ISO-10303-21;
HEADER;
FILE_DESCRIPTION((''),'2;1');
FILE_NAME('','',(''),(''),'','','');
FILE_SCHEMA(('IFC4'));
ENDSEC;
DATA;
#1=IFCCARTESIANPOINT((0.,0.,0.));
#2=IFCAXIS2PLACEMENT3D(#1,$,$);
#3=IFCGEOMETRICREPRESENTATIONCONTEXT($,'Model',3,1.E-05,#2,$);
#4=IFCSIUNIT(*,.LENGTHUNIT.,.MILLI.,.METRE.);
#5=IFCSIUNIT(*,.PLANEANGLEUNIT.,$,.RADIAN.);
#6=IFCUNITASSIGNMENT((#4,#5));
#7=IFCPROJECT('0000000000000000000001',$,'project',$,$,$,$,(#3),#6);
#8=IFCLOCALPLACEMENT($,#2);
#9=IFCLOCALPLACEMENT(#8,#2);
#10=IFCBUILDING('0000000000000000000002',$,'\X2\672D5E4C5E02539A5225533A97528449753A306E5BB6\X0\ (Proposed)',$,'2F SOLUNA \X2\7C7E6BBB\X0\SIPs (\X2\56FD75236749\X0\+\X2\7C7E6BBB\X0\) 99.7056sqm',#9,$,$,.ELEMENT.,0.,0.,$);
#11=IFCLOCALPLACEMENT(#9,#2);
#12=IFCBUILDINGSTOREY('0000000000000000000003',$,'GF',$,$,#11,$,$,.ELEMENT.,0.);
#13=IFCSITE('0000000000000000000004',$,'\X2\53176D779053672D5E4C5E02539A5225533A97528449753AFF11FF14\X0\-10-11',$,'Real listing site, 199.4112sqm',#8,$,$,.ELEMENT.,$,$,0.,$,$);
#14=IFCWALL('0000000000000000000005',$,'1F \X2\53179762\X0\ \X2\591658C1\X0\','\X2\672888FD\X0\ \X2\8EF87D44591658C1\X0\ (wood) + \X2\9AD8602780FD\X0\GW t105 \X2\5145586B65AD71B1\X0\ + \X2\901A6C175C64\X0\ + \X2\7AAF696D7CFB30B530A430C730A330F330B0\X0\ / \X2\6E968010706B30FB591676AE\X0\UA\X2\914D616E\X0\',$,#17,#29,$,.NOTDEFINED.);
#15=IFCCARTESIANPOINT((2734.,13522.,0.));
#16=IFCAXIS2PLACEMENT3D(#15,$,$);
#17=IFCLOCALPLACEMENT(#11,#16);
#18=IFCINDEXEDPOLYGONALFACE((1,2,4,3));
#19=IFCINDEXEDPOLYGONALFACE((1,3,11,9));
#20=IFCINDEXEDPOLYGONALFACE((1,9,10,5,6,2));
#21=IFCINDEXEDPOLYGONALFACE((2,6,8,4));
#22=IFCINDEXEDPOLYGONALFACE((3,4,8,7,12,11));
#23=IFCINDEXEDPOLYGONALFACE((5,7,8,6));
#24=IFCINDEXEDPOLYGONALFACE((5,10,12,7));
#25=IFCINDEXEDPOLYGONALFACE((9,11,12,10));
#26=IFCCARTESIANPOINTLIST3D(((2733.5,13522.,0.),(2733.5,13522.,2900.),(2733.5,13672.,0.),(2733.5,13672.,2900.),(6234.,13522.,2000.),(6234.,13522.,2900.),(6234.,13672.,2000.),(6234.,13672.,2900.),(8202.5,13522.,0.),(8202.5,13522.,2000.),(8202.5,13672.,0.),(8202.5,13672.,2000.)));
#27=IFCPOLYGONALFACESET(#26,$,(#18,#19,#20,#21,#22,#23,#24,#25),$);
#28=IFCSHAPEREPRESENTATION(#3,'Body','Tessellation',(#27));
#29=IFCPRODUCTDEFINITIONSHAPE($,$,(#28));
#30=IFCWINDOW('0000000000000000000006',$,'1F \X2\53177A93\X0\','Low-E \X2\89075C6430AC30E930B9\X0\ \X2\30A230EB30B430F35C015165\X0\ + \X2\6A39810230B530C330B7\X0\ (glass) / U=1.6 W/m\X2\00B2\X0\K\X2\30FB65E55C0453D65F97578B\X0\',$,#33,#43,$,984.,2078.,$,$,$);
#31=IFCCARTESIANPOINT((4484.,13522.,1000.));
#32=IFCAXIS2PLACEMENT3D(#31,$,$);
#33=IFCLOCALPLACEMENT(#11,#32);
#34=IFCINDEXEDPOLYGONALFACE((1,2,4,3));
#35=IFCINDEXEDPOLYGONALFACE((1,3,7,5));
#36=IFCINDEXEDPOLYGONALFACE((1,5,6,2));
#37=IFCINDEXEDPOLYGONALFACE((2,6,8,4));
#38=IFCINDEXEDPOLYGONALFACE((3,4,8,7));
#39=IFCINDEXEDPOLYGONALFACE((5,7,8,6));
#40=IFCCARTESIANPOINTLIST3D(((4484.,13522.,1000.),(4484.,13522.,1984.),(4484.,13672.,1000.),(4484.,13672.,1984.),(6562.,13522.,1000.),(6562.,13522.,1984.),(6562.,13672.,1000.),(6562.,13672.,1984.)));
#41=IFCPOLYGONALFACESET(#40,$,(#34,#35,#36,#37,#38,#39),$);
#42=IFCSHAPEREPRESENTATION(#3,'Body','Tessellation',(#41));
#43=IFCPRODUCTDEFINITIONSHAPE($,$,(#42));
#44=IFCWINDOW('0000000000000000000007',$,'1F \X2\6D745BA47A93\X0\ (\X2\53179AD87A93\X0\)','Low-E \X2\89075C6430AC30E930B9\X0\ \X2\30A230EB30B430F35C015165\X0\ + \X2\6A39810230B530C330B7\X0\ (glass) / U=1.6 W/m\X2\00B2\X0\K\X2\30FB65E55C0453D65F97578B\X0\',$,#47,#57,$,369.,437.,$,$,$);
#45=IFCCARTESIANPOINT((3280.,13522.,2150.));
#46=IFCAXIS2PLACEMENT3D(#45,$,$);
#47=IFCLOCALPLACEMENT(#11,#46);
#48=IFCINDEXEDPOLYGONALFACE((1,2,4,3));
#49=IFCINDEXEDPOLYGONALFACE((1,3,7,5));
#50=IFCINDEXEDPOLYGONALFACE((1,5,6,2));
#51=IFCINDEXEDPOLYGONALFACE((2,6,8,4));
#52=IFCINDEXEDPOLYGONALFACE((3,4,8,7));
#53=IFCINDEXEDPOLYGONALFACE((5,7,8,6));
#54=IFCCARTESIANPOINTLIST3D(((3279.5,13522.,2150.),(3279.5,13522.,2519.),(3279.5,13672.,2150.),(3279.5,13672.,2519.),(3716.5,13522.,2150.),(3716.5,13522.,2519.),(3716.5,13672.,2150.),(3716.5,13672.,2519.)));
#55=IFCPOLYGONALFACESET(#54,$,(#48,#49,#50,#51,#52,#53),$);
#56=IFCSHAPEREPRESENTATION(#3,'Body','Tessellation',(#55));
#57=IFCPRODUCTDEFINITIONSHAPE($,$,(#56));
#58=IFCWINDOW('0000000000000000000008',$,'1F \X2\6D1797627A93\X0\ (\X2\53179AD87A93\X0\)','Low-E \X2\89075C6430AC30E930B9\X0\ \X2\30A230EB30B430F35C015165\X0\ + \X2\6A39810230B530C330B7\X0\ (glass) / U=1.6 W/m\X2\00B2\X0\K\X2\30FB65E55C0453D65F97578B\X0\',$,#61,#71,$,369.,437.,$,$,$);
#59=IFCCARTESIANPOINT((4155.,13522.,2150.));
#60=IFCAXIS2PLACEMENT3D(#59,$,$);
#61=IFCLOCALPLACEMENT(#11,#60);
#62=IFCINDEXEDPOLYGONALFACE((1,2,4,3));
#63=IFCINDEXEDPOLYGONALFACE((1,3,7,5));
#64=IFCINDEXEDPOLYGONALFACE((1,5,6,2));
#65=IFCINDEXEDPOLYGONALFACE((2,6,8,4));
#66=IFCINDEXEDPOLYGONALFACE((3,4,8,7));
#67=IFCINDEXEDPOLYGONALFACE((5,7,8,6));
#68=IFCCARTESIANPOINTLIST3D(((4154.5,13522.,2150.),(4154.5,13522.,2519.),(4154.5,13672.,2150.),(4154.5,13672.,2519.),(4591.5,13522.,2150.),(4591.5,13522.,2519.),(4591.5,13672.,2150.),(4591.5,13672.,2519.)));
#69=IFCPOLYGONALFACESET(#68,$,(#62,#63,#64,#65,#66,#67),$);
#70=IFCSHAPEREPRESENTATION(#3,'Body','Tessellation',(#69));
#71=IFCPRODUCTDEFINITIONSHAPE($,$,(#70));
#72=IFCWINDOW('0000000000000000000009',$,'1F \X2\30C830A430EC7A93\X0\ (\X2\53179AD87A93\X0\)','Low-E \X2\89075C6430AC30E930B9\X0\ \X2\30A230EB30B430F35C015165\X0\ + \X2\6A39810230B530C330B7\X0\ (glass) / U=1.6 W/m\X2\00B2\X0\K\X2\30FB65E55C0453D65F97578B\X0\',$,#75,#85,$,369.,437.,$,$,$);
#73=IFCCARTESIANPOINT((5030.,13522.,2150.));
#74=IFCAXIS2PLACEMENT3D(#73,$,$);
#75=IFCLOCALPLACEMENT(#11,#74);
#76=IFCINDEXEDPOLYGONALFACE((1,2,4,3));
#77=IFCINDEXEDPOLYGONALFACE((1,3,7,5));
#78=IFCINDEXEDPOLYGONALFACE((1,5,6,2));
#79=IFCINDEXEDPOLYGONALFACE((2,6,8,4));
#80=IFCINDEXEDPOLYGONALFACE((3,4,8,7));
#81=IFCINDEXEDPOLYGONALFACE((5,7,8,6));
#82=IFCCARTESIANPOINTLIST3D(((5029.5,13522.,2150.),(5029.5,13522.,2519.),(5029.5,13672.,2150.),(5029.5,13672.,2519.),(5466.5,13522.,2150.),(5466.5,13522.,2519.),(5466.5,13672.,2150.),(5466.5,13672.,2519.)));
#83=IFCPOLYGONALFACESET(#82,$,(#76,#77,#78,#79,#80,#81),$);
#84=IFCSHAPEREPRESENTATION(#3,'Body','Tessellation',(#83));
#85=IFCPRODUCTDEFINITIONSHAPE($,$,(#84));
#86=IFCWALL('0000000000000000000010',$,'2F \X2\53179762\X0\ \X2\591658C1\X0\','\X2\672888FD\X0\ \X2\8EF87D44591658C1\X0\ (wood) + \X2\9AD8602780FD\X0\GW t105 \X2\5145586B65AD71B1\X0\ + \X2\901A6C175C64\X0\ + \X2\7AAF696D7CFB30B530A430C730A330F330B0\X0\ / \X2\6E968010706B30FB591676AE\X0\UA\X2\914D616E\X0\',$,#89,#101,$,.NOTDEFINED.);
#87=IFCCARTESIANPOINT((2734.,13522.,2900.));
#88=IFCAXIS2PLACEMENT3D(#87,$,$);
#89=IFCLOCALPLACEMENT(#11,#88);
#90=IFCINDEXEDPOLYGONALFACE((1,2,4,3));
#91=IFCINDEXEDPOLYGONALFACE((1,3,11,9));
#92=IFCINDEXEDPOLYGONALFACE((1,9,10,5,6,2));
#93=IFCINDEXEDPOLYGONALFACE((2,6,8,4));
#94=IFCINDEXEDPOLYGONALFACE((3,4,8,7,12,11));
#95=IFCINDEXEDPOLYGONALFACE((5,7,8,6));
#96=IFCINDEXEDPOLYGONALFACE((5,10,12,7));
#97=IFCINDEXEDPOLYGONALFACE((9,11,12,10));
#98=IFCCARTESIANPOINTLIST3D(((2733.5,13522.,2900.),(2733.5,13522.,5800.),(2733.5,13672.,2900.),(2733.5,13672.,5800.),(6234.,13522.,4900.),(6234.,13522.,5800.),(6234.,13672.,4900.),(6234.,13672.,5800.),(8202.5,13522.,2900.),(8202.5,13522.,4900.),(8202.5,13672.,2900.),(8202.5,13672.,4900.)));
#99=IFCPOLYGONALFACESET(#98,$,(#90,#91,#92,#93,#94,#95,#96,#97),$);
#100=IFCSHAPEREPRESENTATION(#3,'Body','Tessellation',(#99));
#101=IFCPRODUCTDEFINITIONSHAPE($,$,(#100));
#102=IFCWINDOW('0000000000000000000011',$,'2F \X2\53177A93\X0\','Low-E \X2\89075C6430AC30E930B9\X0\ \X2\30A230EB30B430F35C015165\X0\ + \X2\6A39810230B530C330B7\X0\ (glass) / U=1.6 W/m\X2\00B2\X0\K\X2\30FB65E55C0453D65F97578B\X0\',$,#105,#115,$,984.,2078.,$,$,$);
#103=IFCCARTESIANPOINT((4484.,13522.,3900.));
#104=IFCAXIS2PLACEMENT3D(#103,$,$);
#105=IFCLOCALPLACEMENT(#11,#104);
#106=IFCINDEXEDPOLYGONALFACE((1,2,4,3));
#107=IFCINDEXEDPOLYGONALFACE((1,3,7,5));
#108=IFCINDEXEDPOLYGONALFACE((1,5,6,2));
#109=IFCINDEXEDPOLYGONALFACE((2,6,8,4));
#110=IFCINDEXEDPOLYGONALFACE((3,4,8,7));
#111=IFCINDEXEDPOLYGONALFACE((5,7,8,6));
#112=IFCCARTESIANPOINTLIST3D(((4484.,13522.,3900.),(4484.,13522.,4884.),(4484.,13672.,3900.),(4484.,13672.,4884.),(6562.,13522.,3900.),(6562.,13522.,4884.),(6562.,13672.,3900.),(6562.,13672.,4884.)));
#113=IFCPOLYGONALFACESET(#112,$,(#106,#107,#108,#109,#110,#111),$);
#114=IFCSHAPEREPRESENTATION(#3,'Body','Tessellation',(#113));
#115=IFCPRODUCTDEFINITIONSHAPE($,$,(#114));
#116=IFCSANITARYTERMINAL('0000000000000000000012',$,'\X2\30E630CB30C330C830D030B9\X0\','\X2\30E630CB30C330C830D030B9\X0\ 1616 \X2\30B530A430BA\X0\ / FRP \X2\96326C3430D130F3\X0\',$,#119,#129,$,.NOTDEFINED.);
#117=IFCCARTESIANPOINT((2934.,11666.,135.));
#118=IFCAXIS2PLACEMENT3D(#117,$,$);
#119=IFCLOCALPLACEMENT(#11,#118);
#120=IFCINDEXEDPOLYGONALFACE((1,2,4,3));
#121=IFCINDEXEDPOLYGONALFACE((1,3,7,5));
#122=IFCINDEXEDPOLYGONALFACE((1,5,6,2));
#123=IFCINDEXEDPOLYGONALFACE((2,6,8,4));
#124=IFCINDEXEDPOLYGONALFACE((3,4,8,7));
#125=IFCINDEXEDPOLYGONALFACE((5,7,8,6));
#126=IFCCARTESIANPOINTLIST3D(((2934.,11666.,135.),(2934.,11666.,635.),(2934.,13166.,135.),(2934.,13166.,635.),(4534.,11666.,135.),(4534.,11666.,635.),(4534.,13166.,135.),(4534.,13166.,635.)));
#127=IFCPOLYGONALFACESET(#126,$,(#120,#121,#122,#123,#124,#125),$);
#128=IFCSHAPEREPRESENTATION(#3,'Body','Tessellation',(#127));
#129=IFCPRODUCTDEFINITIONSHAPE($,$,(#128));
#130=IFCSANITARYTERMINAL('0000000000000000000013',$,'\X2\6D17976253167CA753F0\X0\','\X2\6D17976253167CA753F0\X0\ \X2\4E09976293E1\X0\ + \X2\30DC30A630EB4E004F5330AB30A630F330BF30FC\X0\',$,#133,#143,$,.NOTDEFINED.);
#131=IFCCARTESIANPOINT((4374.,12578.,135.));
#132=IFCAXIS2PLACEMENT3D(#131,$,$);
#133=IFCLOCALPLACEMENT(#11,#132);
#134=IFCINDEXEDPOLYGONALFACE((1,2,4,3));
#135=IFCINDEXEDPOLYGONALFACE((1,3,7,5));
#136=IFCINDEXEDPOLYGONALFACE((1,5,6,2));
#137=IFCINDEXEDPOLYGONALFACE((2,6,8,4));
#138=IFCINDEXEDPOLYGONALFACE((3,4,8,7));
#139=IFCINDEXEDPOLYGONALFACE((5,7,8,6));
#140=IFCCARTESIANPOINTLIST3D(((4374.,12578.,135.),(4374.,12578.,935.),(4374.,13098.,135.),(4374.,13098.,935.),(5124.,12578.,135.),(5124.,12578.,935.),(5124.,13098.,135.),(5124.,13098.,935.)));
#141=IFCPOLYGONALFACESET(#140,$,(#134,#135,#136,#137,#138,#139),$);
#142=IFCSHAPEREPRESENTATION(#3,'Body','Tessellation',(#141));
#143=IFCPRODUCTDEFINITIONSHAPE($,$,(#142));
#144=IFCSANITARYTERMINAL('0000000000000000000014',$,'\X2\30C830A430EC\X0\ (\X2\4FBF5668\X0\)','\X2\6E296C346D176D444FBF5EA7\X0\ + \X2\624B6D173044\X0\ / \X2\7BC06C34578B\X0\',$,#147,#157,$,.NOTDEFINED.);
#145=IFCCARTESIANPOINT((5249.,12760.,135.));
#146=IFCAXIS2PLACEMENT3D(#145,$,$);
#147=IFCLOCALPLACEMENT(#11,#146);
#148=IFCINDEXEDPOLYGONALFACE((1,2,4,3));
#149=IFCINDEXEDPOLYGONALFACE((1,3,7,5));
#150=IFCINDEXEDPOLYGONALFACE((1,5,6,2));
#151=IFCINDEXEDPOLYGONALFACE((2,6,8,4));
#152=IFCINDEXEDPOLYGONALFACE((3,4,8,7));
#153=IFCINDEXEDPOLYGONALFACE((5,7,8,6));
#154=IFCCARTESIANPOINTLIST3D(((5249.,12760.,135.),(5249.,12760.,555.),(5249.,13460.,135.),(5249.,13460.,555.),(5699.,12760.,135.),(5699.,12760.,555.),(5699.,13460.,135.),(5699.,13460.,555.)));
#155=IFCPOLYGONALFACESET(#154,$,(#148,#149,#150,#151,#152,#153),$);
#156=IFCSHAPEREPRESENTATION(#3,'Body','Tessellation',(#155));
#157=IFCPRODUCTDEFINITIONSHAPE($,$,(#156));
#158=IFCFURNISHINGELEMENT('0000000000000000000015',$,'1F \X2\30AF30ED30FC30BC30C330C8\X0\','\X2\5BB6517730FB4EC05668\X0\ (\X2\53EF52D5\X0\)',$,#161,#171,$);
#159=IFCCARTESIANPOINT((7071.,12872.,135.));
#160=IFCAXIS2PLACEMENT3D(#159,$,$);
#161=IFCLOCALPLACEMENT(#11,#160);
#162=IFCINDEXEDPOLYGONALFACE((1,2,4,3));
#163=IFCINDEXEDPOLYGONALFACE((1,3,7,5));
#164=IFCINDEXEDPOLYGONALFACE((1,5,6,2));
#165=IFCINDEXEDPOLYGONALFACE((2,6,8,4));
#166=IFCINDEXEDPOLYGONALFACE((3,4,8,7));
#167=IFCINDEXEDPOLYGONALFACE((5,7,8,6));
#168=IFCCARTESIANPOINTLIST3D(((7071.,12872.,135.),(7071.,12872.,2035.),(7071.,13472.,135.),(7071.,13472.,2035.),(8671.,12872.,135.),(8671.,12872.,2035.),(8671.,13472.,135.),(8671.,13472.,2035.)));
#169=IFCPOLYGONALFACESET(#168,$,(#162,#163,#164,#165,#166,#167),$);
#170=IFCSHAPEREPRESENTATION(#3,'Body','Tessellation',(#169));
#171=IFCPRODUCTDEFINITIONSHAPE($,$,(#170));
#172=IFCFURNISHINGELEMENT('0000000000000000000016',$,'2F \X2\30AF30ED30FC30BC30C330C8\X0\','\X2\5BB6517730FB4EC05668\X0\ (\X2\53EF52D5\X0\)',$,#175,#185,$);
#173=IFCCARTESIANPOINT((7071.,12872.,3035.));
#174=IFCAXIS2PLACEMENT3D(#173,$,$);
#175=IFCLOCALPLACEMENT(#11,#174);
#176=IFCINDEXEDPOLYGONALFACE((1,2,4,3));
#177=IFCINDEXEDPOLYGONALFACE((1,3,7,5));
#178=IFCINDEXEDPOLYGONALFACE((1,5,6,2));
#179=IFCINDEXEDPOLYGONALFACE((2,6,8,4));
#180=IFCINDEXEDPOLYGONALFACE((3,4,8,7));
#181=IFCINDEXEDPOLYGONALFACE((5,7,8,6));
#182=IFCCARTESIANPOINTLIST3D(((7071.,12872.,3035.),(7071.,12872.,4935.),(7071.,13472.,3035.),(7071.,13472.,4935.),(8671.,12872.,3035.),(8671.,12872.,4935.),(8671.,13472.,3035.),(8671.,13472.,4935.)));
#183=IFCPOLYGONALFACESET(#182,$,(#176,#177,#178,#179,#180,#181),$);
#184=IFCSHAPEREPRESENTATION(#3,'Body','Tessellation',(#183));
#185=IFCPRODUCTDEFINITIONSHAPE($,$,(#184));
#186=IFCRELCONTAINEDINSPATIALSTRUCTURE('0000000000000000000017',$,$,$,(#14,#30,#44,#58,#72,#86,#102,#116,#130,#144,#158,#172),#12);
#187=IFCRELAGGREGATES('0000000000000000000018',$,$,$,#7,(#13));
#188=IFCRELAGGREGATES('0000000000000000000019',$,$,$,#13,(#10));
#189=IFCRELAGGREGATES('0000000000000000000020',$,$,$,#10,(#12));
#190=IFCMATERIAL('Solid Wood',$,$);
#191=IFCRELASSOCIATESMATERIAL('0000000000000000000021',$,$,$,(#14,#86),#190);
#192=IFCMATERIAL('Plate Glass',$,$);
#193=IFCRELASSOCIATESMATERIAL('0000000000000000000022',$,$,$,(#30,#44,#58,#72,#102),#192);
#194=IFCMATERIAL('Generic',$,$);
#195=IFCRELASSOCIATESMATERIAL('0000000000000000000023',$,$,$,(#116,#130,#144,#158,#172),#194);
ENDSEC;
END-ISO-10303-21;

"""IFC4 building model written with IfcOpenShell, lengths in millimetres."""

from ifc_helpers import new_model, si_unit, frame, frame_2d, origin, place, context, project, spatial, rectangle, extrude, material, element, fill, save


model = new_model("IFC4")

# Units and contexts
model_context = context("Model", 3, precision=1e-05, world=origin())
ifc_project = project(units=[si_unit("LENGTHUNIT", "METRE", prefix="MILLI"), si_unit("PLANEANGLEUNIT", "RADIAN")], contexts=[model_context])

# Site, building, storey
site_placement = place(None, origin())
site = spatial("IfcSite", under=ifc_project, at=site_placement, Name="北海道札幌市厚別区青葉町１４-10-11", ObjectType="Real listing site, 199.4112sqm", CompositionType="ELEMENT", RefElevation=0.0)
building_placement = place(site_placement, origin())
building = spatial("IfcBuilding", under=site, at=building_placement, Name="札幌市厚別区青葉町の家 (Proposed)", ObjectType="2F SOLUNA 籾殻SIPs (国産杉+籾殻) 99.7056sqm", CompositionType="ELEMENT", ElevationOfRefHeight=0.0, ElevationOfTerrain=0.0)
storey_placement = place(building_placement, origin())
storey = spatial("IfcBuildingStorey", under=building, at=storey_placement, Name="GF", CompositionType="ELEMENT", Elevation=0.0)

# Wall, openings, windows
ifc_material_1 = material(Name="Solid Wood")
wall_1_placement = place(storey_placement, frame((2734.0, 13522.0, 0.0)))
wall_1 = element("IfcWall", 1, at=wall_1_placement, inside=storey, material=ifc_material_1, Name="1F 北面 外壁", Description="木製 軸組外壁 (wood) + 高性能GW t105 充填断熱 + 通気層 + 窯業系サイディング / 準耐火・外皮UA配慮", PredefinedType="NOTDEFINED", context=model_context, shape_type="SweptSolid", body=[
    extrude(rectangle(XDim=5469.0, YDim=150.0, at=frame_2d((2734.0, 75.0))), frame((2734.0, 13522.0, 0.0)), (0.0, 0.0, 1.0), 2900.0),
])
opening_1_placement = place(storey_placement, frame((4484.0, 13522.0, 1000.0)))
opening_1 = element("IfcOpeningElement", 2, at=opening_1_placement, cuts=wall_1, PredefinedType="NOTDEFINED", context=model_context, shape_type="SweptSolid", body=[
    extrude(rectangle(XDim=2078.0, YDim=150.0, at=frame_2d((1039.0, 75.0))), frame((4484.0, 13522.0, 1000.0)), (0.0, 0.0, 1.0), 984.0),
])
opening_2_placement = place(storey_placement, frame((3280.0, 13522.0, 2150.0)))
opening_2 = element("IfcOpeningElement", 3, at=opening_2_placement, cuts=wall_1, PredefinedType="NOTDEFINED", context=model_context, shape_type="SweptSolid", body=[
    extrude(rectangle(XDim=437.0, YDim=150.0, at=frame_2d((218.0, 75.0))), frame((3280.0, 13522.0, 2150.0)), (0.0, 0.0, 1.0), 369.0),
])
opening_3_placement = place(storey_placement, frame((4155.0, 13522.0, 2150.0)))
opening_3 = element("IfcOpeningElement", 4, at=opening_3_placement, cuts=wall_1, PredefinedType="NOTDEFINED", context=model_context, shape_type="SweptSolid", body=[
    extrude(rectangle(XDim=437.0, YDim=150.0, at=frame_2d((218.0, 75.0))), frame((4155.0, 13522.0, 2150.0)), (0.0, 0.0, 1.0), 369.0),
])
opening_4_placement = place(storey_placement, frame((5030.0, 13522.0, 2150.0)))
opening_4 = element("IfcOpeningElement", 5, at=opening_4_placement, cuts=wall_1, PredefinedType="NOTDEFINED", context=model_context, shape_type="SweptSolid", body=[
    extrude(rectangle(XDim=437.0, YDim=150.0, at=frame_2d((218.0, 75.0))), frame((5030.0, 13522.0, 2150.0)), (0.0, 0.0, 1.0), 369.0),
])
ifc_material_2 = material(Name="Plate Glass")
window_1_placement = place(storey_placement, frame((4484.0, 13522.0, 1000.0)))
window_1 = element("IfcWindow", 6, at=window_1_placement, inside=storey, material=ifc_material_2, Name="1F 北窓", Description="Low-E 複層ガラス アルゴン封入 + 樹脂サッシ (glass) / U=1.6 W/m²K・日射取得型", OverallHeight=984.0, OverallWidth=2078.0, context=model_context, shape_type="SweptSolid", body=[
    extrude(rectangle(XDim=2078.0, YDim=150.0, at=frame_2d((1039.0, 75.0))), frame((4484.0, 13522.0, 1000.0)), (0.0, 0.0, 1.0), 984.0),
])
fill(opening_1, window_1)
window_2_placement = place(storey_placement, frame((3280.0, 13522.0, 2150.0)))
window_2 = element("IfcWindow", 7, at=window_2_placement, inside=storey, material=ifc_material_2, Name="1F 浴室窓 (北高窓)", Description="Low-E 複層ガラス アルゴン封入 + 樹脂サッシ (glass) / U=1.6 W/m²K・日射取得型", OverallHeight=369.0, OverallWidth=437.0, context=model_context, shape_type="SweptSolid", body=[
    extrude(rectangle(XDim=437.0, YDim=150.0, at=frame_2d((218.0, 75.0))), frame((3280.0, 13522.0, 2150.0)), (0.0, 0.0, 1.0), 369.0),
])
fill(opening_2, window_2)
window_3_placement = place(storey_placement, frame((4155.0, 13522.0, 2150.0)))
window_3 = element("IfcWindow", 8, at=window_3_placement, inside=storey, material=ifc_material_2, Name="1F 洗面窓 (北高窓)", Description="Low-E 複層ガラス アルゴン封入 + 樹脂サッシ (glass) / U=1.6 W/m²K・日射取得型", OverallHeight=369.0, OverallWidth=437.0, context=model_context, shape_type="SweptSolid", body=[
    extrude(rectangle(XDim=437.0, YDim=150.0, at=frame_2d((218.0, 75.0))), frame((4155.0, 13522.0, 2150.0)), (0.0, 0.0, 1.0), 369.0),
])
fill(opening_3, window_3)
window_4_placement = place(storey_placement, frame((5030.0, 13522.0, 2150.0)))
window_4 = element("IfcWindow", 9, at=window_4_placement, inside=storey, material=ifc_material_2, Name="1F トイレ窓 (北高窓)", Description="Low-E 複層ガラス アルゴン封入 + 樹脂サッシ (glass) / U=1.6 W/m²K・日射取得型", OverallHeight=369.0, OverallWidth=437.0, context=model_context, shape_type="SweptSolid", body=[
    extrude(rectangle(XDim=437.0, YDim=150.0, at=frame_2d((218.0, 75.0))), frame((5030.0, 13522.0, 2150.0)), (0.0, 0.0, 1.0), 369.0),
])
fill(opening_4, window_4)

# Wall, opening, window
wall_2_placement = place(storey_placement, frame((2734.0, 13522.0, 2900.0)))
wall_2 = element("IfcWall", 10, at=wall_2_placement, inside=storey, material=ifc_material_1, Name="2F 北面 外壁", Description="木製 軸組外壁 (wood) + 高性能GW t105 充填断熱 + 通気層 + 窯業系サイディング / 準耐火・外皮UA配慮", PredefinedType="NOTDEFINED", context=model_context, shape_type="SweptSolid", body=[
    extrude(rectangle(XDim=5469.0, YDim=150.0, at=frame_2d((2734.0, 75.0))), frame((2734.0, 13522.0, 2900.0)), (0.0, 0.0, 1.0), 2900.0),
])
opening_5_placement = place(storey_placement, frame((4484.0, 13522.0, 3900.0)))
opening_5 = element("IfcOpeningElement", 11, at=opening_5_placement, cuts=wall_2, PredefinedType="NOTDEFINED", context=model_context, shape_type="SweptSolid", body=[
    extrude(rectangle(XDim=2078.0, YDim=150.0, at=frame_2d((1039.0, 75.0))), frame((4484.0, 13522.0, 3900.0)), (0.0, 0.0, 1.0), 984.0),
])
window_5_placement = place(storey_placement, frame((4484.0, 13522.0, 3900.0)))
window_5 = element("IfcWindow", 12, at=window_5_placement, inside=storey, material=ifc_material_2, Name="2F 北窓", Description="Low-E 複層ガラス アルゴン封入 + 樹脂サッシ (glass) / U=1.6 W/m²K・日射取得型", OverallHeight=984.0, OverallWidth=2078.0, context=model_context, shape_type="SweptSolid", body=[
    extrude(rectangle(XDim=2078.0, YDim=150.0, at=frame_2d((1039.0, 75.0))), frame((4484.0, 13522.0, 3900.0)), (0.0, 0.0, 1.0), 984.0),
])
fill(opening_5, window_5)

# Sanitary terminals
ifc_material_3 = material(Name="Generic")
sanitary_terminal_1_placement = place(storey_placement, frame((2934.0, 11666.0, 135.0)))
element("IfcSanitaryTerminal", 13, at=sanitary_terminal_1_placement, inside=storey, material=ifc_material_3, Name="ユニットバス", Description="ユニットバス 1616 サイズ / FRP 防水パン", PredefinedType="NOTDEFINED", context=model_context, shape_type="SweptSolid", body=[
    extrude(rectangle(XDim=1600.0, YDim=1500.0, at=frame_2d((800.0, 750.0))), frame((2934.0, 11666.0, 135.0)), (0.0, 0.0, 1.0), 500.0),
])
sanitary_terminal_2_placement = place(storey_placement, frame((4374.0, 12578.0, 135.0)))
element("IfcSanitaryTerminal", 14, at=sanitary_terminal_2_placement, inside=storey, material=ifc_material_3, Name="洗面化粧台", Description="洗面化粧台 三面鏡 + ボウル一体カウンター", PredefinedType="NOTDEFINED", context=model_context, shape_type="SweptSolid", body=[
    extrude(rectangle(XDim=750.0, YDim=520.0, at=frame_2d((375.0, 260.0))), frame((4374.0, 12578.0, 135.0)), (0.0, 0.0, 1.0), 800.0),
])
sanitary_terminal_3_placement = place(storey_placement, frame((5249.0, 12760.0, 135.0)))
element("IfcSanitaryTerminal", 15, at=sanitary_terminal_3_placement, inside=storey, material=ifc_material_3, Name="トイレ (便器)", Description="温水洗浄便座 + 手洗い / 節水型", PredefinedType="NOTDEFINED", context=model_context, shape_type="SweptSolid", body=[
    extrude(rectangle(XDim=450.0, YDim=700.0, at=frame_2d((225.0, 350.0))), frame((5249.0, 12760.0, 135.0)), (0.0, 0.0, 1.0), 420.0),
])

# Furnishing elements
furnishing_1_placement = place(storey_placement, frame((7071.0, 12872.0, 135.0)))
element("IfcFurnishingElement", 16, at=furnishing_1_placement, inside=storey, material=ifc_material_3, Name="1F クローゼット", Description="家具・什器 (可動)", context=model_context, shape_type="SweptSolid", body=[
    extrude(rectangle(XDim=1600.0, YDim=600.0, at=frame_2d((800.0, 300.0))), frame((7071.0, 12872.0, 135.0)), (0.0, 0.0, 1.0), 1900.0),
])
furnishing_2_placement = place(storey_placement, frame((7071.0, 12872.0, 3035.0)))
element("IfcFurnishingElement", 17, at=furnishing_2_placement, inside=storey, material=ifc_material_3, Name="2F クローゼット", Description="家具・什器 (可動)", context=model_context, shape_type="SweptSolid", body=[
    extrude(rectangle(XDim=1600.0, YDim=600.0, at=frame_2d((800.0, 300.0))), frame((7071.0, 12872.0, 3035.0)), (0.0, 0.0, 1.0), 1900.0),
])

save(model, "model.ifc")
